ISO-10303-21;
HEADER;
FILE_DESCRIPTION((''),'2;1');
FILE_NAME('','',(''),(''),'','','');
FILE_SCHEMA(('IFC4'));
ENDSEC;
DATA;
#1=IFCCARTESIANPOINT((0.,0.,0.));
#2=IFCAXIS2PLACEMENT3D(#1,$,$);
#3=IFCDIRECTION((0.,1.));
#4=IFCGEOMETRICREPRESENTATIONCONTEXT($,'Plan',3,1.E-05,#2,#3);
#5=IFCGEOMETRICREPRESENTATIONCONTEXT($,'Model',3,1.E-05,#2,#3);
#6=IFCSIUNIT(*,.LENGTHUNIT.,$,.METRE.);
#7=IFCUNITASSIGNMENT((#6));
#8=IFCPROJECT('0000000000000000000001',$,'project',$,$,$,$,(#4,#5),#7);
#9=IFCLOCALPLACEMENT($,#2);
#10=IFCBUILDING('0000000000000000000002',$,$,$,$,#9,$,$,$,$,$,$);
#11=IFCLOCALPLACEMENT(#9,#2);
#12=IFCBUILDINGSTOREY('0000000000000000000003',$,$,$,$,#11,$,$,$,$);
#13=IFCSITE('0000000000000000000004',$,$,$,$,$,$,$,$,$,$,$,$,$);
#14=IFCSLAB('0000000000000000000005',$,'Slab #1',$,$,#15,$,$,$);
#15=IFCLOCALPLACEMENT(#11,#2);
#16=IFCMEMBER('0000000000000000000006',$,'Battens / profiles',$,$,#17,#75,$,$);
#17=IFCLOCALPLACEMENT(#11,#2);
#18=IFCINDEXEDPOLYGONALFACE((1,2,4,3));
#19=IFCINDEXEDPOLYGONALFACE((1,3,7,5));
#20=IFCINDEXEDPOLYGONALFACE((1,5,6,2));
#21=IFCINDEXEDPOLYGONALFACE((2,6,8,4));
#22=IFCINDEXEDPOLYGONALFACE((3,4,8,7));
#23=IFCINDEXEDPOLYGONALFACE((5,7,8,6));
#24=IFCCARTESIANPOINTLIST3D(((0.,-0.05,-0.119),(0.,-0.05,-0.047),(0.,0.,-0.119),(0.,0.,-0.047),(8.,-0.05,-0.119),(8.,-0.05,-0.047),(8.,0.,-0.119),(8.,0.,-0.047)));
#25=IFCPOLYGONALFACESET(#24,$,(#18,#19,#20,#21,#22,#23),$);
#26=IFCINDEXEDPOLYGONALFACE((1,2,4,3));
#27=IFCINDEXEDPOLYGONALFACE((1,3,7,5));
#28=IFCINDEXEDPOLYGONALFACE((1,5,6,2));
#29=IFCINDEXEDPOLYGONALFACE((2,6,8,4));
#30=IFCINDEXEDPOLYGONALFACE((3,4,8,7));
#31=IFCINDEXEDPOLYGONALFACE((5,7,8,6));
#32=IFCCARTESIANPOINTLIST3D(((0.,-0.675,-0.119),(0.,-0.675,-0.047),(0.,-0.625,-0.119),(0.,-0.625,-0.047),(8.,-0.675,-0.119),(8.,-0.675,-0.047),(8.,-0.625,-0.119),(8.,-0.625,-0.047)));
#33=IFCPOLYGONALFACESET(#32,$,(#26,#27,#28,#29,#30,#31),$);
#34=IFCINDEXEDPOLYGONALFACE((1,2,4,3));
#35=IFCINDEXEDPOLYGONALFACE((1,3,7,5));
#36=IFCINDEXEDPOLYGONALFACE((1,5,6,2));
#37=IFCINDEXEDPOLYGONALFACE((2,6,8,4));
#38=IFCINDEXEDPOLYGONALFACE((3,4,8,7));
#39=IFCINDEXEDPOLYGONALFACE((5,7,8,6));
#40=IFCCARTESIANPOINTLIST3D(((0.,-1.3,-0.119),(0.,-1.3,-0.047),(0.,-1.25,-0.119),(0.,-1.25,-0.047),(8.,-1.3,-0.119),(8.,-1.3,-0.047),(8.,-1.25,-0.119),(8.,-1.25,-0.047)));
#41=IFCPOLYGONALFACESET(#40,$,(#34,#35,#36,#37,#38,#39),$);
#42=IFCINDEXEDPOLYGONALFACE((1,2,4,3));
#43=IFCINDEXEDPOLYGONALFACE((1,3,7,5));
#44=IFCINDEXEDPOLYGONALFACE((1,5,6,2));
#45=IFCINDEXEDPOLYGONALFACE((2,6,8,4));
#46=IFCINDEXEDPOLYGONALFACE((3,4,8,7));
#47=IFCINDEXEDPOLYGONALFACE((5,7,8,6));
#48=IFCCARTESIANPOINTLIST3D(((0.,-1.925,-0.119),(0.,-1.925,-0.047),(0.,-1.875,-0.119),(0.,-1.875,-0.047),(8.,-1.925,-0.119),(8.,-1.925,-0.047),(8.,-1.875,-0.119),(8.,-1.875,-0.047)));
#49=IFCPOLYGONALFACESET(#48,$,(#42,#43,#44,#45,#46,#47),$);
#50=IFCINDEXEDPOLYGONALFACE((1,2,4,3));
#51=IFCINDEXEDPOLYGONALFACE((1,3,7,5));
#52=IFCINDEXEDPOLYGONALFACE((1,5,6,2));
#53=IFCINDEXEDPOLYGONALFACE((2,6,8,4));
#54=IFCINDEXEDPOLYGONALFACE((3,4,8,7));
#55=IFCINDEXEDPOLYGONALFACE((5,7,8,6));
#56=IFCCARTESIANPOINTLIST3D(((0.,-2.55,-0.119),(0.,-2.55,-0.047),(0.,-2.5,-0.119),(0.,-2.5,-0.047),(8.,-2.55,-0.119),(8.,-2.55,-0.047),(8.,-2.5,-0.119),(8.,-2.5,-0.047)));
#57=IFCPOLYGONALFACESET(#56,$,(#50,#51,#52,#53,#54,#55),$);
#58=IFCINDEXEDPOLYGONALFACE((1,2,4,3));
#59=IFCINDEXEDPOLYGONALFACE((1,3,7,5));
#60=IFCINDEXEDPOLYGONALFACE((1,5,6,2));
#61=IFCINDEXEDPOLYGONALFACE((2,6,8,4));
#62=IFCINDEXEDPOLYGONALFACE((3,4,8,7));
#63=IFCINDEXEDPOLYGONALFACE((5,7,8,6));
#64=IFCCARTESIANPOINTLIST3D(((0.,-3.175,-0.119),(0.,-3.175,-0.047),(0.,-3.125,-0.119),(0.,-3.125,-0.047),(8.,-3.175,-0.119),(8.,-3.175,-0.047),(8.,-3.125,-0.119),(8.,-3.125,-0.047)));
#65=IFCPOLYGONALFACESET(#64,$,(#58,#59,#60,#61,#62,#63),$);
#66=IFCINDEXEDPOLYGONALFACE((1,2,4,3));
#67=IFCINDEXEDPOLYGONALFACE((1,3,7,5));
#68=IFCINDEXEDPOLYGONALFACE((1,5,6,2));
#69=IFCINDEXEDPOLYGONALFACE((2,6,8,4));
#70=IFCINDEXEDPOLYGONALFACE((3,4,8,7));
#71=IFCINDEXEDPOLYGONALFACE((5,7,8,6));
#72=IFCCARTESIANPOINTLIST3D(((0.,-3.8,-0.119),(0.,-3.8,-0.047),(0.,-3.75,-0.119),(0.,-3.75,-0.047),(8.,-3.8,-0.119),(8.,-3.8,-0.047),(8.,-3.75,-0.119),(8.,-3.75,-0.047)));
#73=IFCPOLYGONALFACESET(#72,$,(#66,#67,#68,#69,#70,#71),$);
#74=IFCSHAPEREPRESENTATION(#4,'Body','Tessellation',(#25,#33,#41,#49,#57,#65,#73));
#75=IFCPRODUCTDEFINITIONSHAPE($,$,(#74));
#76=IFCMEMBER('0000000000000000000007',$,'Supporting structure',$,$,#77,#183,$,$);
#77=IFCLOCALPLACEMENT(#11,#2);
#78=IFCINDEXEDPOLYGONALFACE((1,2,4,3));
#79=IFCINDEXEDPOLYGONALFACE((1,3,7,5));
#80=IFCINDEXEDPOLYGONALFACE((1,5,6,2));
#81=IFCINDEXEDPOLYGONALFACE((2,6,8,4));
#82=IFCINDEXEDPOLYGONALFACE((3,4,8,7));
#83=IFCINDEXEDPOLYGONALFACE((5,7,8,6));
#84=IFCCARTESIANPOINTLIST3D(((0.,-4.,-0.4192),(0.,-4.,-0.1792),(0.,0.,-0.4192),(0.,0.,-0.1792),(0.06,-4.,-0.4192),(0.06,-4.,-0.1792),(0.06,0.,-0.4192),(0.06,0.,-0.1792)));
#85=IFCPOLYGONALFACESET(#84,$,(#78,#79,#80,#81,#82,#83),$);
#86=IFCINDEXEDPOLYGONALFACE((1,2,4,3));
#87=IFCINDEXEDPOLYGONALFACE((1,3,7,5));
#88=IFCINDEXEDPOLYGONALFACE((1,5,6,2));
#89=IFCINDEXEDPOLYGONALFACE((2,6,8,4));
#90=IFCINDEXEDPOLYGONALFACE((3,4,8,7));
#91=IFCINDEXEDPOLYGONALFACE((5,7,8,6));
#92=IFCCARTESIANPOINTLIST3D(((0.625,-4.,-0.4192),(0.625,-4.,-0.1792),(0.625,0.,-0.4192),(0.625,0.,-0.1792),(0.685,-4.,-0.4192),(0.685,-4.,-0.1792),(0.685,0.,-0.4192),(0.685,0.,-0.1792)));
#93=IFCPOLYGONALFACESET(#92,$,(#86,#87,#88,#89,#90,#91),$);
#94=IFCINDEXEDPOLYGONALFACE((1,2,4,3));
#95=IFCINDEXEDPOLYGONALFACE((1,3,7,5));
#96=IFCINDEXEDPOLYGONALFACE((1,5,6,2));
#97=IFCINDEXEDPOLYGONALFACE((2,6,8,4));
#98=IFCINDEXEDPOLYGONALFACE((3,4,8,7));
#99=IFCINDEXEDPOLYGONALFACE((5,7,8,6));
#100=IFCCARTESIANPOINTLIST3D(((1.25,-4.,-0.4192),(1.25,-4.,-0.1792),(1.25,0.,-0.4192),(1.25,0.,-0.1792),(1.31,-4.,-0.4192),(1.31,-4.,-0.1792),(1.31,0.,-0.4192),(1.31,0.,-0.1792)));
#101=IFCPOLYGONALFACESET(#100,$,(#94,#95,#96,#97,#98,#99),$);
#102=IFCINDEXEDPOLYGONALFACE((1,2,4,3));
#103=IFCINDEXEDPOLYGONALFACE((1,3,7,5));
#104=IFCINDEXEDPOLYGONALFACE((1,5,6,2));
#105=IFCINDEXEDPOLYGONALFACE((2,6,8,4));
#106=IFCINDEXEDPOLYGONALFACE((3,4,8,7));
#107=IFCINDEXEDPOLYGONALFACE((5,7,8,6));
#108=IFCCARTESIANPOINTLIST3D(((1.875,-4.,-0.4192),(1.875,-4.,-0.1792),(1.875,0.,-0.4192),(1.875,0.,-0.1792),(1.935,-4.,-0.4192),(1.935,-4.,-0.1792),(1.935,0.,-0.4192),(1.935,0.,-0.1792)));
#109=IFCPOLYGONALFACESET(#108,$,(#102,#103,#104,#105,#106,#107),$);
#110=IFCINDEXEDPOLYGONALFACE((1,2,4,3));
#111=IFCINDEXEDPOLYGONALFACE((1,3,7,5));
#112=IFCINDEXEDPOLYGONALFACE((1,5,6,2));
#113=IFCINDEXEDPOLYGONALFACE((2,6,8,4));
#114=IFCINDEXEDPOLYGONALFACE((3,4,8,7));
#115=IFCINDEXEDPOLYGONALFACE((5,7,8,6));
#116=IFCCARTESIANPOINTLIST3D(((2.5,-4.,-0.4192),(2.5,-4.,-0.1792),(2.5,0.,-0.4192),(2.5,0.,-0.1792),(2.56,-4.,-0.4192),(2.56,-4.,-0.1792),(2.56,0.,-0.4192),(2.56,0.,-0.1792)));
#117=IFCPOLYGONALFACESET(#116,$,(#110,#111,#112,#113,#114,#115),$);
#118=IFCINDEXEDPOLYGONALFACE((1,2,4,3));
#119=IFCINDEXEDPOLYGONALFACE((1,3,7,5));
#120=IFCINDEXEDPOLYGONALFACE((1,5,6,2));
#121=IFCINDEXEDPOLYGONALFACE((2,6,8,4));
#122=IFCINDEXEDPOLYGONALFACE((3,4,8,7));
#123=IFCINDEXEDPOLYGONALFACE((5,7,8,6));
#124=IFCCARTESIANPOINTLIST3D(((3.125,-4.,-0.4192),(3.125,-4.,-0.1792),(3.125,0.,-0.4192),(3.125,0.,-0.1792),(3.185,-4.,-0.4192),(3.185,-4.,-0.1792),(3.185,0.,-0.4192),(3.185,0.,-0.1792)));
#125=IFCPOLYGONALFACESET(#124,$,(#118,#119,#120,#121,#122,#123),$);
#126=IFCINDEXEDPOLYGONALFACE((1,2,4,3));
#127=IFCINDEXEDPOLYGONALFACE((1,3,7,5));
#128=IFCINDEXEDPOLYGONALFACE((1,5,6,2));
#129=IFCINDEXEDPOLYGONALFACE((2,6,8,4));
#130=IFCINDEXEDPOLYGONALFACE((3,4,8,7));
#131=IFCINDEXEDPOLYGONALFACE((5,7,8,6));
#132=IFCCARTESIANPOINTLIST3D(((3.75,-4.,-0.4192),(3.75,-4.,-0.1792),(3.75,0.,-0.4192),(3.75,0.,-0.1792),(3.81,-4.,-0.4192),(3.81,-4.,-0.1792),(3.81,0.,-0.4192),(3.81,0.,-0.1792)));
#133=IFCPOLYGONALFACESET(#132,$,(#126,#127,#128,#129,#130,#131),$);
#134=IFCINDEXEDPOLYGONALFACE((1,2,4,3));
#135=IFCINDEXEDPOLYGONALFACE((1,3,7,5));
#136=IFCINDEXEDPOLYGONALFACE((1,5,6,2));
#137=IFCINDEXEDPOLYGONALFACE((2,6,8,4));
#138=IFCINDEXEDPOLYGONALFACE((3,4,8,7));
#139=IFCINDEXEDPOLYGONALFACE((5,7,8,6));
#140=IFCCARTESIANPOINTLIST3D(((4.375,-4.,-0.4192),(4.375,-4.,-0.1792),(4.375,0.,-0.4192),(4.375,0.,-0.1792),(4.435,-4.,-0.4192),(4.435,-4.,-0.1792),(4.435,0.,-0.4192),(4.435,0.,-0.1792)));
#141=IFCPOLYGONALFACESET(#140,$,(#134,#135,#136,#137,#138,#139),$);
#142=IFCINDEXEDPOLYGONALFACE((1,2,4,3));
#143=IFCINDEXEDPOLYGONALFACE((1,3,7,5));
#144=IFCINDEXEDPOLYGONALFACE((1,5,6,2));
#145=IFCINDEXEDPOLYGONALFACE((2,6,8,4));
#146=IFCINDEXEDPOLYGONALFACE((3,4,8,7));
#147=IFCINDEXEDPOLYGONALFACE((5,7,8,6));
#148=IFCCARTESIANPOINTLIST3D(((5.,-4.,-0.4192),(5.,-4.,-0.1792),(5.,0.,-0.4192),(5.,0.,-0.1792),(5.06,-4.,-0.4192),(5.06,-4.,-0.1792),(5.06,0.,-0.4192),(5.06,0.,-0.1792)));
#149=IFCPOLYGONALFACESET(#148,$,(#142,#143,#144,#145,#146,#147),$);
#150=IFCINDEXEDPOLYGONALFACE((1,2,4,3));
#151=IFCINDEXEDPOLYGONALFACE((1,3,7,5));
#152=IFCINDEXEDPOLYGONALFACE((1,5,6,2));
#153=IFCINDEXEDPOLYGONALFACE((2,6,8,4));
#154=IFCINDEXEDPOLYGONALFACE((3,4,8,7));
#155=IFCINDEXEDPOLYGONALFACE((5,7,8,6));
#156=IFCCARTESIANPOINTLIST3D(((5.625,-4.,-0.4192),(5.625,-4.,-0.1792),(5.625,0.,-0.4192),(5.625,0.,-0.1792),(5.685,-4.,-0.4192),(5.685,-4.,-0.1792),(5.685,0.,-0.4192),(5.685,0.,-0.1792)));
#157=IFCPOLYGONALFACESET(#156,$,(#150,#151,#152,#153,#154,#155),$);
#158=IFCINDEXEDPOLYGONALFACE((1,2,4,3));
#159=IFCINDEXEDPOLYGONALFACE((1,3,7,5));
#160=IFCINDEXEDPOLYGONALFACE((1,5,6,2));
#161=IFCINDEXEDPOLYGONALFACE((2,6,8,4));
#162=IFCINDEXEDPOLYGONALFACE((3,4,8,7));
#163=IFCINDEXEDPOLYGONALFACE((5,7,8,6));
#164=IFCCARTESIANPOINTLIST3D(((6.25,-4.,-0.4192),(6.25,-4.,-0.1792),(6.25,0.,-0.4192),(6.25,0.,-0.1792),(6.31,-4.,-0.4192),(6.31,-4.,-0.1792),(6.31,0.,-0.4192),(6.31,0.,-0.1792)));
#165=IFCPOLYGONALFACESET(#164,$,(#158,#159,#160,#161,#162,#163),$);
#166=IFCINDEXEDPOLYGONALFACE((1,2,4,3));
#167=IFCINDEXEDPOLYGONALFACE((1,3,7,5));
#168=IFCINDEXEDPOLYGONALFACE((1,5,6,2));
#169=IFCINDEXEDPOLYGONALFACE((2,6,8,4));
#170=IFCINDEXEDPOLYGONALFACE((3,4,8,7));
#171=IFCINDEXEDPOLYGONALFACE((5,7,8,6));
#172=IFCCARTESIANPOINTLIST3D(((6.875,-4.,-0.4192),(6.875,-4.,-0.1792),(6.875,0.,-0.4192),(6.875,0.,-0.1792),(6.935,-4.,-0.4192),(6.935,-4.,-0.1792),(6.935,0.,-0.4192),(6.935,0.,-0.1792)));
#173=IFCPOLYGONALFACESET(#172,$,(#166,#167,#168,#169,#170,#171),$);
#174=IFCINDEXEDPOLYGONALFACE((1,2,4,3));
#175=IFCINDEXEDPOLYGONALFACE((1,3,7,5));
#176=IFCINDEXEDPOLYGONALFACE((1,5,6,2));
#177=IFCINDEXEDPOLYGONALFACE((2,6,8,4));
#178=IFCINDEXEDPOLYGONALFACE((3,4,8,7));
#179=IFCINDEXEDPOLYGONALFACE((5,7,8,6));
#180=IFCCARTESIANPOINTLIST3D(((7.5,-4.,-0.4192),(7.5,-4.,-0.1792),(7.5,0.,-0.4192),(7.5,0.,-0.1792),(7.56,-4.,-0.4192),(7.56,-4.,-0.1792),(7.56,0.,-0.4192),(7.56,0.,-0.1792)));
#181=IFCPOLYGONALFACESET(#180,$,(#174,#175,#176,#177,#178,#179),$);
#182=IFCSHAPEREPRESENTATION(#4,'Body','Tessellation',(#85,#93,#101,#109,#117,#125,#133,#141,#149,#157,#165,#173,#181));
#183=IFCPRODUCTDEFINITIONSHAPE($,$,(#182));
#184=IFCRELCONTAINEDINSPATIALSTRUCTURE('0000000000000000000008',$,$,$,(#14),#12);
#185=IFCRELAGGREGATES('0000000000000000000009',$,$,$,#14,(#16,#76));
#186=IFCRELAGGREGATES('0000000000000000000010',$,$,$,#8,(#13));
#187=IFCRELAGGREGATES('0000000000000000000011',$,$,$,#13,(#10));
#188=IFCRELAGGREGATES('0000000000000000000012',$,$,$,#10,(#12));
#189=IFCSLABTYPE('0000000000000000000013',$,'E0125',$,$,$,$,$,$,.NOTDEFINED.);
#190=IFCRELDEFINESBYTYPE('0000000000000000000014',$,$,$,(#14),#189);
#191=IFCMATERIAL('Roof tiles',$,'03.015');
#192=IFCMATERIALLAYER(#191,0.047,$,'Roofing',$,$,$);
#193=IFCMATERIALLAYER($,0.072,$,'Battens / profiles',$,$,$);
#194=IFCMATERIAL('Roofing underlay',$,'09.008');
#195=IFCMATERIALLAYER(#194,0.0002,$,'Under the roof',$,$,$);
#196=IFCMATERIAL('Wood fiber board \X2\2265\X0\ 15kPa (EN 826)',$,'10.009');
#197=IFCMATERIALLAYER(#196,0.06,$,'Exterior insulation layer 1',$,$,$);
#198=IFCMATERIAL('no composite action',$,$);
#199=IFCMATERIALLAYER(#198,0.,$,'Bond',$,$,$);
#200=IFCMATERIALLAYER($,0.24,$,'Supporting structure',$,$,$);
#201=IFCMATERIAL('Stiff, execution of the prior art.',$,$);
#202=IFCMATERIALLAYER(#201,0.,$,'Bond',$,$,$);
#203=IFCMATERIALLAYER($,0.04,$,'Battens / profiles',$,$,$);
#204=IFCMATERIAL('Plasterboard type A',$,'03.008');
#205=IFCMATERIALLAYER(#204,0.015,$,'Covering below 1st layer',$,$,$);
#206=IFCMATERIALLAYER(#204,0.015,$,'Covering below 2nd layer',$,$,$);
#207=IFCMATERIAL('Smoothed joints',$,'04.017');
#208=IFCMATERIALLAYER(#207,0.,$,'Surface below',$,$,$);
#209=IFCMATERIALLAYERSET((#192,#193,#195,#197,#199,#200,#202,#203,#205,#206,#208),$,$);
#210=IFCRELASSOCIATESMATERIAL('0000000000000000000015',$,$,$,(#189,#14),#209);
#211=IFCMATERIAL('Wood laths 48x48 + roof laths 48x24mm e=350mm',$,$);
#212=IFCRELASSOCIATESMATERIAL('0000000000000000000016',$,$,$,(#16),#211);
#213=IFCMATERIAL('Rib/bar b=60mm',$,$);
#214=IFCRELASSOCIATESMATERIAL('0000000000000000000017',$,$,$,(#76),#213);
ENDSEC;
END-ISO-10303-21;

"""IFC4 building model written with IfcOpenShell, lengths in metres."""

from ifc_helpers import new_model, si_unit, direction, frame, frame_2d, origin, place, context, project, spatial, rectangle, extrude, material, layer, layer_set, type_object, element, aggregate, save


model = new_model("IFC4")

# Units and contexts
plan_context = context("Plan", 3, precision=1e-05, world=origin(), true_north=direction((0.0, 1.0)))
model_context = context("Model", 3, precision=1e-05, world=origin(), true_north=direction((0.0, 1.0)))
ifc_project = project(units=[si_unit("LENGTHUNIT", "METRE")], contexts=[plan_context, model_context])

# Site, building, storey
site = spatial("IfcSite", under=ifc_project)
building_placement = place(None, origin())
building = spatial("IfcBuilding", under=site, at=building_placement)
storey_placement = place(building_placement, origin())
storey = spatial("IfcBuildingStorey", under=building, at=storey_placement)

# Slab, members
ifc_material_1 = material(Name="Roof tiles", Category="03.015")
ifc_layer_1 = layer(ifc_material_1, 0.047, Name="Roofing")
ifc_layer_2 = layer(None, 0.072, Name="Battens / profiles")
ifc_material_2 = material(Name="Roofing underlay", Category="09.008")
ifc_layer_3 = layer(ifc_material_2, 0.0002, Name="Under the roof")
ifc_material_3 = material(Name="Wood fiber board ≥ 15kPa (EN 826)", Category="10.009")
ifc_layer_4 = layer(ifc_material_3, 0.06, Name="Exterior insulation layer 1")
ifc_material_4 = material(Name="no composite action")
ifc_layer_5 = layer(ifc_material_4, 0.0, Name="Bond")
ifc_layer_6 = layer(None, 0.24, Name="Supporting structure")
ifc_material_5 = material(Name="Stiff, execution of the prior art.")
ifc_layer_7 = layer(ifc_material_5, 0.0, Name="Bond")
ifc_layer_8 = layer(None, 0.04, Name="Battens / profiles")
ifc_material_6 = material(Name="Plasterboard type A", Category="03.008")
ifc_layer_9 = layer(ifc_material_6, 0.015, Name="Covering below 1st layer")
ifc_layer_10 = layer(ifc_material_6, 0.015, Name="Covering below 2nd layer")
ifc_material_7 = material(Name="Smoothed joints", Category="04.017")
ifc_layer_11 = layer(ifc_material_7, 0.0, Name="Surface below")
ifc_layer_set = layer_set([ifc_layer_1, ifc_layer_2, ifc_layer_3, ifc_layer_4, ifc_layer_5, ifc_layer_6, ifc_layer_7, ifc_layer_8, ifc_layer_9, ifc_layer_10, ifc_layer_11])
slab_type = type_object("IfcSlabType", Name="E0125", PredefinedType="NOTDEFINED", material=ifc_layer_set)
slab_placement = place(None, frame((0.0, 0.0, 0.0), z_axis=(0.0, 0.0, -1.0), x_axis=(1.0, 0.0, 0.0)))
slab = element("IfcSlab", 1, at=slab_placement, inside=storey, type_object=slab_type, material=ifc_layer_set, Name="Slab #1")
ifc_material_8 = material(Name="Wood laths 48x48 + roof laths 48x24mm e=350mm")
member_1_placement = place(slab_placement, origin())
member_1 = element("IfcMember", 2, at=member_1_placement, material=ifc_material_8, Name="Battens / profiles", context=plan_context, shape_type="SweptSolid", body=[
    extrude(rectangle(XDim=0.05, YDim=0.072, at=frame_2d((0.025, 0.036), x_axis=(1.0, 0.0))), frame((0.0, 0.0, 0.047), z_axis=(1.0, 0.0, 0.0), x_axis=(0.0, 1.0, 0.0)), (0.0, 0.0, 1.0), 8.0),
    extrude(rectangle(XDim=0.05, YDim=0.072, at=frame_2d((0.025, 0.036), x_axis=(1.0, 0.0))), frame((0.0, 0.625, 0.047), z_axis=(1.0, 0.0, 0.0), x_axis=(0.0, 1.0, 0.0)), (0.0, 0.0, 1.0), 8.0),
    extrude(rectangle(XDim=0.05, YDim=0.072, at=frame_2d((0.025, 0.036), x_axis=(1.0, 0.0))), frame((0.0, 1.25, 0.047), z_axis=(1.0, 0.0, 0.0), x_axis=(0.0, 1.0, 0.0)), (0.0, 0.0, 1.0), 8.0),
    extrude(rectangle(XDim=0.05, YDim=0.072, at=frame_2d((0.025, 0.036), x_axis=(1.0, 0.0))), frame((0.0, 1.875, 0.047), z_axis=(1.0, 0.0, 0.0), x_axis=(0.0, 1.0, 0.0)), (0.0, 0.0, 1.0), 8.0),
    extrude(rectangle(XDim=0.05, YDim=0.072, at=frame_2d((0.025, 0.036), x_axis=(1.0, 0.0))), frame((0.0, 2.5, 0.047), z_axis=(1.0, 0.0, 0.0), x_axis=(0.0, 1.0, 0.0)), (0.0, 0.0, 1.0), 8.0),
    extrude(rectangle(XDim=0.05, YDim=0.072, at=frame_2d((0.025, 0.036), x_axis=(1.0, 0.0))), frame((0.0, 3.125, 0.047), z_axis=(1.0, 0.0, 0.0), x_axis=(0.0, 1.0, 0.0)), (0.0, 0.0, 1.0), 8.0),
    extrude(rectangle(XDim=0.05, YDim=0.072, at=frame_2d((0.025, 0.036), x_axis=(1.0, 0.0))), frame((0.0, 3.75, 0.047), z_axis=(1.0, 0.0, 0.0), x_axis=(0.0, 1.0, 0.0)), (0.0, 0.0, 1.0), 8.0),
])
ifc_material_9 = material(Name="Rib/bar b=60mm")
member_2_placement = place(slab_placement, origin())
member_2 = element("IfcMember", 3, at=member_2_placement, material=ifc_material_9, Name="Supporting structure", context=plan_context, shape_type="SweptSolid", body=[
    extrude(rectangle(XDim=0.06, YDim=0.24, at=frame_2d((0.03, 0.12), x_axis=(1.0, 0.0))), frame((0.0, 4.0, 0.1792), z_axis=(0.0, -1.0, 0.0), x_axis=(1.0, 0.0, 0.0)), (0.0, 0.0, 1.0), 4.0),
    extrude(rectangle(XDim=0.06, YDim=0.24, at=frame_2d((0.03, 0.12), x_axis=(1.0, 0.0))), frame((0.625, 4.0, 0.1792), z_axis=(0.0, -1.0, 0.0), x_axis=(1.0, 0.0, 0.0)), (0.0, 0.0, 1.0), 4.0),
    extrude(rectangle(XDim=0.06, YDim=0.24, at=frame_2d((0.03, 0.12), x_axis=(1.0, 0.0))), frame((1.25, 4.0, 0.1792), z_axis=(0.0, -1.0, 0.0), x_axis=(1.0, 0.0, 0.0)), (0.0, 0.0, 1.0), 4.0),
    extrude(rectangle(XDim=0.06, YDim=0.24, at=frame_2d((0.03, 0.12), x_axis=(1.0, 0.0))), frame((1.875, 4.0, 0.1792), z_axis=(0.0, -1.0, 0.0), x_axis=(1.0, 0.0, 0.0)), (0.0, 0.0, 1.0), 4.0),
    extrude(rectangle(XDim=0.06, YDim=0.24, at=frame_2d((0.03, 0.12), x_axis=(1.0, 0.0))), frame((2.5, 4.0, 0.1792), z_axis=(0.0, -1.0, 0.0), x_axis=(1.0, 0.0, 0.0)), (0.0, 0.0, 1.0), 4.0),
    extrude(rectangle(XDim=0.06, YDim=0.24, at=frame_2d((0.03, 0.12), x_axis=(1.0, 0.0))), frame((3.125, 4.0, 0.1792), z_axis=(0.0, -1.0, 0.0), x_axis=(1.0, 0.0, 0.0)), (0.0, 0.0, 1.0), 4.0),
    extrude(rectangle(XDim=0.06, YDim=0.24, at=frame_2d((0.03, 0.12), x_axis=(1.0, 0.0))), frame((3.75, 4.0, 0.1792), z_axis=(0.0, -1.0, 0.0), x_axis=(1.0, 0.0, 0.0)), (0.0, 0.0, 1.0), 4.0),
    extrude(rectangle(XDim=0.06, YDim=0.24, at=frame_2d((0.03, 0.12), x_axis=(1.0, 0.0))), frame((4.375, 4.0, 0.1792), z_axis=(0.0, -1.0, 0.0), x_axis=(1.0, 0.0, 0.0)), (0.0, 0.0, 1.0), 4.0),
    extrude(rectangle(XDim=0.06, YDim=0.24, at=frame_2d((0.03, 0.12), x_axis=(1.0, 0.0))), frame((5.0, 4.0, 0.1792), z_axis=(0.0, -1.0, 0.0), x_axis=(1.0, 0.0, 0.0)), (0.0, 0.0, 1.0), 4.0),
    extrude(rectangle(XDim=0.06, YDim=0.24, at=frame_2d((0.03, 0.12), x_axis=(1.0, 0.0))), frame((5.625, 4.0, 0.1792), z_axis=(0.0, -1.0, 0.0), x_axis=(1.0, 0.0, 0.0)), (0.0, 0.0, 1.0), 4.0),
    extrude(rectangle(XDim=0.06, YDim=0.24, at=frame_2d((0.03, 0.12), x_axis=(1.0, 0.0))), frame((6.25, 4.0, 0.1792), z_axis=(0.0, -1.0, 0.0), x_axis=(1.0, 0.0, 0.0)), (0.0, 0.0, 1.0), 4.0),
    extrude(rectangle(XDim=0.06, YDim=0.24, at=frame_2d((0.03, 0.12), x_axis=(1.0, 0.0))), frame((6.875, 4.0, 0.1792), z_axis=(0.0, -1.0, 0.0), x_axis=(1.0, 0.0, 0.0)), (0.0, 0.0, 1.0), 4.0),
    extrude(rectangle(XDim=0.06, YDim=0.24, at=frame_2d((0.03, 0.12), x_axis=(1.0, 0.0))), frame((7.5, 4.0, 0.1792), z_axis=(0.0, -1.0, 0.0), x_axis=(1.0, 0.0, 0.0)), (0.0, 0.0, 1.0), 4.0),
])
aggregate(slab, [member_1, member_2])

save(model, "model.ifc")
